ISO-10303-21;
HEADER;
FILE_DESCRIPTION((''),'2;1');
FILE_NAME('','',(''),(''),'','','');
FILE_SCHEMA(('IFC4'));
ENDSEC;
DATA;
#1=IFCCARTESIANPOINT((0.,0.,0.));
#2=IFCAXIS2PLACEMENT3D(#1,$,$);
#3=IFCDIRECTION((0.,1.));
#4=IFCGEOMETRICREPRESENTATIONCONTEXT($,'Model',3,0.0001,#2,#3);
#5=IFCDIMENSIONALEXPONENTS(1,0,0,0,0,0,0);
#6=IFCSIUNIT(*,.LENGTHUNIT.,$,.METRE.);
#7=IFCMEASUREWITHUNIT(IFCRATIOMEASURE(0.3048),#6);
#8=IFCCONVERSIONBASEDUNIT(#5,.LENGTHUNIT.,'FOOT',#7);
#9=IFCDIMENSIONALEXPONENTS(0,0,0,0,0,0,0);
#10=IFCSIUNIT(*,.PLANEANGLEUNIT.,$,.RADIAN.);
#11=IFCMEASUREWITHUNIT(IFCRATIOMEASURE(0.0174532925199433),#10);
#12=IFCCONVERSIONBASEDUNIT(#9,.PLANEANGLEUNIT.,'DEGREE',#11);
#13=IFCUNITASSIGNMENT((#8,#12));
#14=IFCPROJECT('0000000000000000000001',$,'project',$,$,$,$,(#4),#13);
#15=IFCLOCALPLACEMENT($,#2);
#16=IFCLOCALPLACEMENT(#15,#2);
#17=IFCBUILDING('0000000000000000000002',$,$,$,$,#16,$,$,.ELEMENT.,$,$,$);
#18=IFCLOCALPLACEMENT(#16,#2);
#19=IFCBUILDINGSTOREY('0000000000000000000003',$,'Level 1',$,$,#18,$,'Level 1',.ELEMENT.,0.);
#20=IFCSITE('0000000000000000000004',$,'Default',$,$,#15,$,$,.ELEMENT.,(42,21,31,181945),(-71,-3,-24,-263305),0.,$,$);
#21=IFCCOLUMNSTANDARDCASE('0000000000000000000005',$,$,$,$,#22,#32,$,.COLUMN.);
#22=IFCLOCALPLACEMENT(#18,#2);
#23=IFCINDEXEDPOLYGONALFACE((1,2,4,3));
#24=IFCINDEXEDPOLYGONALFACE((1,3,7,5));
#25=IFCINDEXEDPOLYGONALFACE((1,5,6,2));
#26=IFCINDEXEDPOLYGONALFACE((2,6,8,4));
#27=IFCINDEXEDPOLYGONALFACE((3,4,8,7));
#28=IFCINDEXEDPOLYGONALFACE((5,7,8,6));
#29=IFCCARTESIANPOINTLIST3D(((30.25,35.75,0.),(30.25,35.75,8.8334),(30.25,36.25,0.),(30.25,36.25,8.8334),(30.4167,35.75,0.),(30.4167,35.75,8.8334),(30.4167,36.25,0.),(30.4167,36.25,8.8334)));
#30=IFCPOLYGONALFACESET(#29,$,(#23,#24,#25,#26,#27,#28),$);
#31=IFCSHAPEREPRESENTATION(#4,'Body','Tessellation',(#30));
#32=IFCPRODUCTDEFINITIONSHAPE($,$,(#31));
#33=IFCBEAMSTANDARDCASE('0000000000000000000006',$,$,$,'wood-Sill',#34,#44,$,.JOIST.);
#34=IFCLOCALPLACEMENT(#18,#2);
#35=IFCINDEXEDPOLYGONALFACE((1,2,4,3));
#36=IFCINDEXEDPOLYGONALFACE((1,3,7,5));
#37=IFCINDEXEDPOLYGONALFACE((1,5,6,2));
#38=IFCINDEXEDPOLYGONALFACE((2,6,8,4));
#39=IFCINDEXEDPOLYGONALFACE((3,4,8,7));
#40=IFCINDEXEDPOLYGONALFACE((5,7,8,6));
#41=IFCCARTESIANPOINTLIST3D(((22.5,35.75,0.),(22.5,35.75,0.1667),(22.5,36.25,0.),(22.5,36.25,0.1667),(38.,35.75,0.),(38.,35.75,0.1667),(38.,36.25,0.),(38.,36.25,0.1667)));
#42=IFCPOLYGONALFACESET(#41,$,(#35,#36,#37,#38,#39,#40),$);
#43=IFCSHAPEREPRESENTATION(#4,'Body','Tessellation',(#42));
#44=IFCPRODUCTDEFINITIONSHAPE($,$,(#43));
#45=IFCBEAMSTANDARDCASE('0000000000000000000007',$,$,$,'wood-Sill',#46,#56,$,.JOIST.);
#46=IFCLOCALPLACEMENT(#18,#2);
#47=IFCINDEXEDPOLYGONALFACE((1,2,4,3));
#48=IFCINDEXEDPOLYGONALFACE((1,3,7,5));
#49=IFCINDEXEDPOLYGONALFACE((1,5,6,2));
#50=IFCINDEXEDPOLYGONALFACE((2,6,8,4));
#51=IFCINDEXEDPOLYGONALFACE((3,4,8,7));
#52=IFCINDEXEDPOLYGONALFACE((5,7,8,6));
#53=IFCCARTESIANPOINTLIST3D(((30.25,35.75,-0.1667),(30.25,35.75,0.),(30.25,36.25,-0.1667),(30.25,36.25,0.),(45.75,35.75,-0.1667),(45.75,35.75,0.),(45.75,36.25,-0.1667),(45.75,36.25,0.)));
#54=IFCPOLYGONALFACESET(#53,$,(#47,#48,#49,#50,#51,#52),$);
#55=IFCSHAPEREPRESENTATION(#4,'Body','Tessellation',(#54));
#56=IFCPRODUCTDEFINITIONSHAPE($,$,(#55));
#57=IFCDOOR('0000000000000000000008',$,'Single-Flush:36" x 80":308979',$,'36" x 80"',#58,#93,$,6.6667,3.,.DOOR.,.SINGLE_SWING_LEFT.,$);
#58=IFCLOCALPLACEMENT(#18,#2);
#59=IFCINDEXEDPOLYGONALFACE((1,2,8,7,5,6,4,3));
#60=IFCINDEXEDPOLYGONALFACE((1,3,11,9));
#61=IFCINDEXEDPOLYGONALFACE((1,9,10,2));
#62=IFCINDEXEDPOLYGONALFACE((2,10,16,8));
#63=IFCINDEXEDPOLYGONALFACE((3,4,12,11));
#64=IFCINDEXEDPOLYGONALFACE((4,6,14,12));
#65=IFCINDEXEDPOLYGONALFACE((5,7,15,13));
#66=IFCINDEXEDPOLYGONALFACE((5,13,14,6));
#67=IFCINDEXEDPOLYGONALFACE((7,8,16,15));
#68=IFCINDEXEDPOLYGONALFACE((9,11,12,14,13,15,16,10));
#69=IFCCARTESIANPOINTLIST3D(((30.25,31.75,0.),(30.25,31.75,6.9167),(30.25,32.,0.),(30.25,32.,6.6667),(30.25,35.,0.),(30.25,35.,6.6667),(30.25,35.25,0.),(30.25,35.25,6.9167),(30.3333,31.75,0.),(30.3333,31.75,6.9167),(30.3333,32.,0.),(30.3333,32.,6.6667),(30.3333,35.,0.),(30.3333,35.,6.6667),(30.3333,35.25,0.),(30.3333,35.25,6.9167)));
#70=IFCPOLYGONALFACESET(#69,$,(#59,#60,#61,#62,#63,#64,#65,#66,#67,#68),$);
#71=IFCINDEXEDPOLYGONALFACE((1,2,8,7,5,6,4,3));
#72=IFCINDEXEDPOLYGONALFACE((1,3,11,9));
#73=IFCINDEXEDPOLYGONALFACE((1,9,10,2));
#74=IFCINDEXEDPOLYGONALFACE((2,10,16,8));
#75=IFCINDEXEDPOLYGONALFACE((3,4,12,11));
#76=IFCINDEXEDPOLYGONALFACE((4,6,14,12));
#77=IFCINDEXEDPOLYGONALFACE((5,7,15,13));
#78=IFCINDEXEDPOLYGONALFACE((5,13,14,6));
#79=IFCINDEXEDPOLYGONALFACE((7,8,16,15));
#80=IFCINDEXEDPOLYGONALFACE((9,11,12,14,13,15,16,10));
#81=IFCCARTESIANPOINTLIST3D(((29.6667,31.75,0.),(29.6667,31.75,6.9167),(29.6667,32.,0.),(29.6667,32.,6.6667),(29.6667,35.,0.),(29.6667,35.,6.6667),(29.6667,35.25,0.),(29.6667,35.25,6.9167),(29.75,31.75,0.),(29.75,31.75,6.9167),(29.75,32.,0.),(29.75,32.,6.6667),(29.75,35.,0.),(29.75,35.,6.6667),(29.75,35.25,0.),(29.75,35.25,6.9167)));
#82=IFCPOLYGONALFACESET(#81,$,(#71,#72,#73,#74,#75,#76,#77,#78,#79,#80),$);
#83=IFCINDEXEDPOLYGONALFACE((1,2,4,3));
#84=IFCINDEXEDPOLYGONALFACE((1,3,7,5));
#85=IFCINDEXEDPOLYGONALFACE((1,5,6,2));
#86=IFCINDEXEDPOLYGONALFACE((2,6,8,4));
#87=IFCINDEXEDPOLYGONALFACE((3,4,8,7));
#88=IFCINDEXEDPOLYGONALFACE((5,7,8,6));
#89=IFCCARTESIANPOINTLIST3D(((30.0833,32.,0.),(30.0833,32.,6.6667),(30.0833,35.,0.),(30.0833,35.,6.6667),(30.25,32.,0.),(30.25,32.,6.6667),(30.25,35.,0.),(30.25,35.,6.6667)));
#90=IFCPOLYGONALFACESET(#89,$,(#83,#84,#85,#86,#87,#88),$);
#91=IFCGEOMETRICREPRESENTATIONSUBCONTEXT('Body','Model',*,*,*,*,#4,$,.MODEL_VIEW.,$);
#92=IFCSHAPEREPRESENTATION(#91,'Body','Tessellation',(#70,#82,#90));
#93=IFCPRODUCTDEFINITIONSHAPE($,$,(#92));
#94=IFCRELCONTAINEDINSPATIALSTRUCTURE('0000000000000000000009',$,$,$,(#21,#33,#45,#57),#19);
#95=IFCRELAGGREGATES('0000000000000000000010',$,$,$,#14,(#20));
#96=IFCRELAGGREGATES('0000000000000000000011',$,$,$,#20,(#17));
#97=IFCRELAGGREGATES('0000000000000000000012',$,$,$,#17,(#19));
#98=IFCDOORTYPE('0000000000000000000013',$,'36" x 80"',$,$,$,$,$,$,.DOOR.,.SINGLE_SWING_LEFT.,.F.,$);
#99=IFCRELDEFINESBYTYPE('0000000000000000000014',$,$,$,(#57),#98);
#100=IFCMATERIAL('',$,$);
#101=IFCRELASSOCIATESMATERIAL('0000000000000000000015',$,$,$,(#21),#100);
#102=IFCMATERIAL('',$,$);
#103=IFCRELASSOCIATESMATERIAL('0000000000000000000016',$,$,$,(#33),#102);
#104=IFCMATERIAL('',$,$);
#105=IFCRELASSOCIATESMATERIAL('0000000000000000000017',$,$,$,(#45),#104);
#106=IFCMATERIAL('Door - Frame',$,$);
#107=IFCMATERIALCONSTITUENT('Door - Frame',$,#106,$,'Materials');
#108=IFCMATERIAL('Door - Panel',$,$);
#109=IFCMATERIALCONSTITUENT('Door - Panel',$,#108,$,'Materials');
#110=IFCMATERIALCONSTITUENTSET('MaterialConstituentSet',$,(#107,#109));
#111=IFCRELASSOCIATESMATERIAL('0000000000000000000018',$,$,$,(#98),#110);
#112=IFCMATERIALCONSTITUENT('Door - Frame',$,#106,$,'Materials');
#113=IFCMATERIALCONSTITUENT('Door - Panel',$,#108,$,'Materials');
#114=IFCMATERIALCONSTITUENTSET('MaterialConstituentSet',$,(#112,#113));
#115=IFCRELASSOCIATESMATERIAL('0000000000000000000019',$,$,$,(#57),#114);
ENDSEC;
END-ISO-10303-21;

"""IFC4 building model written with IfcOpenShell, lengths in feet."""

from ifc_helpers import new_model, entity, si_unit, converted_unit, direction, frame, origin, origin_with_axes, origin_2d_with_axis, place, context, subcontext, project, spatial, polyline, rectangle, outline, extrude, source, transform, mapped, material, constituent, constituent_set, type_object, type_shapes, element, save


model = new_model("IFC4")

# Units and contexts
model_context = context("Model", 3, precision=0.0001, world=origin(), true_north=direction((0.0, 1.0)))
body_context = subcontext(model_context, "Body", "Model", "MODEL_VIEW")
ifc_project = project(units=[converted_unit("LENGTHUNIT", "FOOT", entity("IfcRatioMeasure", 0.3048), si_unit("LENGTHUNIT", "METRE"), dimensions=[1, 0, 0, 0, 0, 0, 0]), converted_unit("PLANEANGLEUNIT", "DEGREE", entity("IfcRatioMeasure", 0.0174532925199433), si_unit("PLANEANGLEUNIT", "RADIAN"), dimensions=[0, 0, 0, 0, 0, 0, 0])], contexts=[model_context])

# Site, building, storey
site_placement = place(None, origin())
site = spatial("IfcSite", under=ifc_project, at=site_placement, Name="Default", CompositionType="ELEMENT", RefLatitude=(42, 21, 31, 181945), RefLongitude=(-71, -3, -24, -263305), RefElevation=0.0)
building_placement = place(site_placement, origin())
building = spatial("IfcBuilding", under=site, at=building_placement, CompositionType="ELEMENT")
storey_placement = place(building_placement, origin())
storey = spatial("IfcBuildingStorey", under=building, at=storey_placement, Name="Level 1", LongName="Level 1", CompositionType="ELEMENT", Elevation=0.0)

# Column
placement_1 = place(storey_placement, frame((30.0, 45.75, 0.0), z_axis=(0.0, 0.0, 1.0), x_axis=(0.0, -1.0, 0.0)))
ifc_material_1 = material(Name="")
placement_2 = place(storey_placement, frame((30.25, 36.0, 0.0)))
for number, where, z_axis, x_axis in (
    (1, (0.0833, 0.0, 0.0), (0.0, 0.0, 1.0), (1.0, 0.0, 0.0)),
):
    element("IfcColumnStandardCase", number, at=place(placement_2, frame(where, z_axis=z_axis, x_axis=x_axis)), inside=storey, material=ifc_material_1, PredefinedType="COLUMN", context=model_context, shape_type="SweptSolid", body=[
        extrude(rectangle(XDim=0.1667, YDim=0.5), origin(), (0.0, 0.0, 1.0), 8.8334),
    ])

# Beams
ifc_material_2 = material(Name="")
beam_1_placement = place(placement_2, origin_with_axes())
element("IfcBeamStandardCase", 2, at=beam_1_placement, inside=storey, material=ifc_material_2, ObjectType="wood-Sill", PredefinedType="JOIST", context=model_context, shape_type="SweptSolid", body=[
    extrude(rectangle(XDim=15.5, YDim=0.5), origin(), (0.0, 0.0, 1.0), 0.1667),
])
ifc_material_3 = material(Name="")
beam_2_placement = place(placement_2, frame((7.75, 0.0, -0.1667), z_axis=(0.0, 0.0, 1.0), x_axis=(1.0, 0.0, 0.0)))
element("IfcBeamStandardCase", 3, at=beam_2_placement, inside=storey, material=ifc_material_3, ObjectType="wood-Sill", PredefinedType="JOIST", context=model_context, shape_type="SweptSolid", body=[
    extrude(rectangle(XDim=15.5, YDim=0.5), origin(), (0.0, 0.0, 1.0), 0.1667),
])

# Door
ifc_material_4 = material(Name="Door - Frame")
ifc_constituent_1 = constituent(ifc_material_4, Name="Door - Frame", Category="Materials")
ifc_material_5 = material(Name="Door - Panel")
ifc_constituent_2 = constituent(ifc_material_5, Name="Door - Panel", Category="Materials")
ifc_constituent_set_1 = constituent_set(constituents=[ifc_constituent_1, ifc_constituent_2], Name="MaterialConstituentSet")
ifc_constituent_3 = constituent(ifc_material_4, Name="Door - Frame", Category="Materials")
ifc_constituent_4 = constituent(ifc_material_5, Name="Door - Panel", Category="Materials")
ifc_constituent_set_2 = constituent_set(constituents=[ifc_constituent_3, ifc_constituent_4], Name="MaterialConstituentSet")
door_type = type_object("IfcDoorType", Name="36\" x 80\"", OperationType="SINGLE_SWING_LEFT", ParameterTakesPrecedence=False, PredefinedType="DOOR", material=ifc_constituent_set_2)
shared_shape = source(origin(), body_context, "Body", "SweptSolid", [
    extrude(outline(polyline([(-1.75, -3.5208), (1.75, -3.5208), (1.75, 3.3958), (1.5, 3.3958), (1.5, -3.2708), (-1.5, -3.2708), (-1.5, 3.3958), (-1.75, 3.3958), (-1.75, -3.5208)])), frame((1.5, 0.5833, 3.3958), z_axis=(0.0, -1.0, 0.0), x_axis=(-1.0, 0.0, 0.0)), (0.0, 0.0, 1.0), 0.0833),
    extrude(outline(polyline([(-3.5208, -1.75), (3.3958, -1.75), (3.3958, -1.5), (-3.2708, -1.5), (-3.2708, 1.5), (3.3958, 1.5), (3.3958, 1.75), (-3.5208, 1.75), (-3.5208, -1.75)])), frame((1.5, 0.0, 3.3958), z_axis=(0.0, -1.0, 0.0), x_axis=(0.0, 0.0, -1.0)), (0.0, 0.0, 1.0), 0.0833),
    extrude(rectangle(XDim=3.0, YDim=0.1667, at=origin_2d_with_axis()), frame((1.5, 0.4167, 0.0)), (0.0, 0.0, 1.0), 6.6667),
])
type_shapes(door_type, [shared_shape])
placement_3 = place(placement_1, frame((10.75, -0.25, 0.0)))
door_placement = place(placement_3, origin())
element("IfcDoor", 4, at=door_placement, inside=storey, type_object=door_type, material=ifc_constituent_set_1, Name="Single-Flush:36\" x 80\":308979", ObjectType="36\" x 80\"", OperationType="SINGLE_SWING_LEFT", OverallHeight=6.6667, OverallWidth=3.0, PredefinedType="DOOR", context=body_context, shape_type="MappedRepresentation", body=[
    mapped(shared_shape, transform((0.0, 0.0, 0.0), scale=1.0)),
])

save(model, "model.ifc")
